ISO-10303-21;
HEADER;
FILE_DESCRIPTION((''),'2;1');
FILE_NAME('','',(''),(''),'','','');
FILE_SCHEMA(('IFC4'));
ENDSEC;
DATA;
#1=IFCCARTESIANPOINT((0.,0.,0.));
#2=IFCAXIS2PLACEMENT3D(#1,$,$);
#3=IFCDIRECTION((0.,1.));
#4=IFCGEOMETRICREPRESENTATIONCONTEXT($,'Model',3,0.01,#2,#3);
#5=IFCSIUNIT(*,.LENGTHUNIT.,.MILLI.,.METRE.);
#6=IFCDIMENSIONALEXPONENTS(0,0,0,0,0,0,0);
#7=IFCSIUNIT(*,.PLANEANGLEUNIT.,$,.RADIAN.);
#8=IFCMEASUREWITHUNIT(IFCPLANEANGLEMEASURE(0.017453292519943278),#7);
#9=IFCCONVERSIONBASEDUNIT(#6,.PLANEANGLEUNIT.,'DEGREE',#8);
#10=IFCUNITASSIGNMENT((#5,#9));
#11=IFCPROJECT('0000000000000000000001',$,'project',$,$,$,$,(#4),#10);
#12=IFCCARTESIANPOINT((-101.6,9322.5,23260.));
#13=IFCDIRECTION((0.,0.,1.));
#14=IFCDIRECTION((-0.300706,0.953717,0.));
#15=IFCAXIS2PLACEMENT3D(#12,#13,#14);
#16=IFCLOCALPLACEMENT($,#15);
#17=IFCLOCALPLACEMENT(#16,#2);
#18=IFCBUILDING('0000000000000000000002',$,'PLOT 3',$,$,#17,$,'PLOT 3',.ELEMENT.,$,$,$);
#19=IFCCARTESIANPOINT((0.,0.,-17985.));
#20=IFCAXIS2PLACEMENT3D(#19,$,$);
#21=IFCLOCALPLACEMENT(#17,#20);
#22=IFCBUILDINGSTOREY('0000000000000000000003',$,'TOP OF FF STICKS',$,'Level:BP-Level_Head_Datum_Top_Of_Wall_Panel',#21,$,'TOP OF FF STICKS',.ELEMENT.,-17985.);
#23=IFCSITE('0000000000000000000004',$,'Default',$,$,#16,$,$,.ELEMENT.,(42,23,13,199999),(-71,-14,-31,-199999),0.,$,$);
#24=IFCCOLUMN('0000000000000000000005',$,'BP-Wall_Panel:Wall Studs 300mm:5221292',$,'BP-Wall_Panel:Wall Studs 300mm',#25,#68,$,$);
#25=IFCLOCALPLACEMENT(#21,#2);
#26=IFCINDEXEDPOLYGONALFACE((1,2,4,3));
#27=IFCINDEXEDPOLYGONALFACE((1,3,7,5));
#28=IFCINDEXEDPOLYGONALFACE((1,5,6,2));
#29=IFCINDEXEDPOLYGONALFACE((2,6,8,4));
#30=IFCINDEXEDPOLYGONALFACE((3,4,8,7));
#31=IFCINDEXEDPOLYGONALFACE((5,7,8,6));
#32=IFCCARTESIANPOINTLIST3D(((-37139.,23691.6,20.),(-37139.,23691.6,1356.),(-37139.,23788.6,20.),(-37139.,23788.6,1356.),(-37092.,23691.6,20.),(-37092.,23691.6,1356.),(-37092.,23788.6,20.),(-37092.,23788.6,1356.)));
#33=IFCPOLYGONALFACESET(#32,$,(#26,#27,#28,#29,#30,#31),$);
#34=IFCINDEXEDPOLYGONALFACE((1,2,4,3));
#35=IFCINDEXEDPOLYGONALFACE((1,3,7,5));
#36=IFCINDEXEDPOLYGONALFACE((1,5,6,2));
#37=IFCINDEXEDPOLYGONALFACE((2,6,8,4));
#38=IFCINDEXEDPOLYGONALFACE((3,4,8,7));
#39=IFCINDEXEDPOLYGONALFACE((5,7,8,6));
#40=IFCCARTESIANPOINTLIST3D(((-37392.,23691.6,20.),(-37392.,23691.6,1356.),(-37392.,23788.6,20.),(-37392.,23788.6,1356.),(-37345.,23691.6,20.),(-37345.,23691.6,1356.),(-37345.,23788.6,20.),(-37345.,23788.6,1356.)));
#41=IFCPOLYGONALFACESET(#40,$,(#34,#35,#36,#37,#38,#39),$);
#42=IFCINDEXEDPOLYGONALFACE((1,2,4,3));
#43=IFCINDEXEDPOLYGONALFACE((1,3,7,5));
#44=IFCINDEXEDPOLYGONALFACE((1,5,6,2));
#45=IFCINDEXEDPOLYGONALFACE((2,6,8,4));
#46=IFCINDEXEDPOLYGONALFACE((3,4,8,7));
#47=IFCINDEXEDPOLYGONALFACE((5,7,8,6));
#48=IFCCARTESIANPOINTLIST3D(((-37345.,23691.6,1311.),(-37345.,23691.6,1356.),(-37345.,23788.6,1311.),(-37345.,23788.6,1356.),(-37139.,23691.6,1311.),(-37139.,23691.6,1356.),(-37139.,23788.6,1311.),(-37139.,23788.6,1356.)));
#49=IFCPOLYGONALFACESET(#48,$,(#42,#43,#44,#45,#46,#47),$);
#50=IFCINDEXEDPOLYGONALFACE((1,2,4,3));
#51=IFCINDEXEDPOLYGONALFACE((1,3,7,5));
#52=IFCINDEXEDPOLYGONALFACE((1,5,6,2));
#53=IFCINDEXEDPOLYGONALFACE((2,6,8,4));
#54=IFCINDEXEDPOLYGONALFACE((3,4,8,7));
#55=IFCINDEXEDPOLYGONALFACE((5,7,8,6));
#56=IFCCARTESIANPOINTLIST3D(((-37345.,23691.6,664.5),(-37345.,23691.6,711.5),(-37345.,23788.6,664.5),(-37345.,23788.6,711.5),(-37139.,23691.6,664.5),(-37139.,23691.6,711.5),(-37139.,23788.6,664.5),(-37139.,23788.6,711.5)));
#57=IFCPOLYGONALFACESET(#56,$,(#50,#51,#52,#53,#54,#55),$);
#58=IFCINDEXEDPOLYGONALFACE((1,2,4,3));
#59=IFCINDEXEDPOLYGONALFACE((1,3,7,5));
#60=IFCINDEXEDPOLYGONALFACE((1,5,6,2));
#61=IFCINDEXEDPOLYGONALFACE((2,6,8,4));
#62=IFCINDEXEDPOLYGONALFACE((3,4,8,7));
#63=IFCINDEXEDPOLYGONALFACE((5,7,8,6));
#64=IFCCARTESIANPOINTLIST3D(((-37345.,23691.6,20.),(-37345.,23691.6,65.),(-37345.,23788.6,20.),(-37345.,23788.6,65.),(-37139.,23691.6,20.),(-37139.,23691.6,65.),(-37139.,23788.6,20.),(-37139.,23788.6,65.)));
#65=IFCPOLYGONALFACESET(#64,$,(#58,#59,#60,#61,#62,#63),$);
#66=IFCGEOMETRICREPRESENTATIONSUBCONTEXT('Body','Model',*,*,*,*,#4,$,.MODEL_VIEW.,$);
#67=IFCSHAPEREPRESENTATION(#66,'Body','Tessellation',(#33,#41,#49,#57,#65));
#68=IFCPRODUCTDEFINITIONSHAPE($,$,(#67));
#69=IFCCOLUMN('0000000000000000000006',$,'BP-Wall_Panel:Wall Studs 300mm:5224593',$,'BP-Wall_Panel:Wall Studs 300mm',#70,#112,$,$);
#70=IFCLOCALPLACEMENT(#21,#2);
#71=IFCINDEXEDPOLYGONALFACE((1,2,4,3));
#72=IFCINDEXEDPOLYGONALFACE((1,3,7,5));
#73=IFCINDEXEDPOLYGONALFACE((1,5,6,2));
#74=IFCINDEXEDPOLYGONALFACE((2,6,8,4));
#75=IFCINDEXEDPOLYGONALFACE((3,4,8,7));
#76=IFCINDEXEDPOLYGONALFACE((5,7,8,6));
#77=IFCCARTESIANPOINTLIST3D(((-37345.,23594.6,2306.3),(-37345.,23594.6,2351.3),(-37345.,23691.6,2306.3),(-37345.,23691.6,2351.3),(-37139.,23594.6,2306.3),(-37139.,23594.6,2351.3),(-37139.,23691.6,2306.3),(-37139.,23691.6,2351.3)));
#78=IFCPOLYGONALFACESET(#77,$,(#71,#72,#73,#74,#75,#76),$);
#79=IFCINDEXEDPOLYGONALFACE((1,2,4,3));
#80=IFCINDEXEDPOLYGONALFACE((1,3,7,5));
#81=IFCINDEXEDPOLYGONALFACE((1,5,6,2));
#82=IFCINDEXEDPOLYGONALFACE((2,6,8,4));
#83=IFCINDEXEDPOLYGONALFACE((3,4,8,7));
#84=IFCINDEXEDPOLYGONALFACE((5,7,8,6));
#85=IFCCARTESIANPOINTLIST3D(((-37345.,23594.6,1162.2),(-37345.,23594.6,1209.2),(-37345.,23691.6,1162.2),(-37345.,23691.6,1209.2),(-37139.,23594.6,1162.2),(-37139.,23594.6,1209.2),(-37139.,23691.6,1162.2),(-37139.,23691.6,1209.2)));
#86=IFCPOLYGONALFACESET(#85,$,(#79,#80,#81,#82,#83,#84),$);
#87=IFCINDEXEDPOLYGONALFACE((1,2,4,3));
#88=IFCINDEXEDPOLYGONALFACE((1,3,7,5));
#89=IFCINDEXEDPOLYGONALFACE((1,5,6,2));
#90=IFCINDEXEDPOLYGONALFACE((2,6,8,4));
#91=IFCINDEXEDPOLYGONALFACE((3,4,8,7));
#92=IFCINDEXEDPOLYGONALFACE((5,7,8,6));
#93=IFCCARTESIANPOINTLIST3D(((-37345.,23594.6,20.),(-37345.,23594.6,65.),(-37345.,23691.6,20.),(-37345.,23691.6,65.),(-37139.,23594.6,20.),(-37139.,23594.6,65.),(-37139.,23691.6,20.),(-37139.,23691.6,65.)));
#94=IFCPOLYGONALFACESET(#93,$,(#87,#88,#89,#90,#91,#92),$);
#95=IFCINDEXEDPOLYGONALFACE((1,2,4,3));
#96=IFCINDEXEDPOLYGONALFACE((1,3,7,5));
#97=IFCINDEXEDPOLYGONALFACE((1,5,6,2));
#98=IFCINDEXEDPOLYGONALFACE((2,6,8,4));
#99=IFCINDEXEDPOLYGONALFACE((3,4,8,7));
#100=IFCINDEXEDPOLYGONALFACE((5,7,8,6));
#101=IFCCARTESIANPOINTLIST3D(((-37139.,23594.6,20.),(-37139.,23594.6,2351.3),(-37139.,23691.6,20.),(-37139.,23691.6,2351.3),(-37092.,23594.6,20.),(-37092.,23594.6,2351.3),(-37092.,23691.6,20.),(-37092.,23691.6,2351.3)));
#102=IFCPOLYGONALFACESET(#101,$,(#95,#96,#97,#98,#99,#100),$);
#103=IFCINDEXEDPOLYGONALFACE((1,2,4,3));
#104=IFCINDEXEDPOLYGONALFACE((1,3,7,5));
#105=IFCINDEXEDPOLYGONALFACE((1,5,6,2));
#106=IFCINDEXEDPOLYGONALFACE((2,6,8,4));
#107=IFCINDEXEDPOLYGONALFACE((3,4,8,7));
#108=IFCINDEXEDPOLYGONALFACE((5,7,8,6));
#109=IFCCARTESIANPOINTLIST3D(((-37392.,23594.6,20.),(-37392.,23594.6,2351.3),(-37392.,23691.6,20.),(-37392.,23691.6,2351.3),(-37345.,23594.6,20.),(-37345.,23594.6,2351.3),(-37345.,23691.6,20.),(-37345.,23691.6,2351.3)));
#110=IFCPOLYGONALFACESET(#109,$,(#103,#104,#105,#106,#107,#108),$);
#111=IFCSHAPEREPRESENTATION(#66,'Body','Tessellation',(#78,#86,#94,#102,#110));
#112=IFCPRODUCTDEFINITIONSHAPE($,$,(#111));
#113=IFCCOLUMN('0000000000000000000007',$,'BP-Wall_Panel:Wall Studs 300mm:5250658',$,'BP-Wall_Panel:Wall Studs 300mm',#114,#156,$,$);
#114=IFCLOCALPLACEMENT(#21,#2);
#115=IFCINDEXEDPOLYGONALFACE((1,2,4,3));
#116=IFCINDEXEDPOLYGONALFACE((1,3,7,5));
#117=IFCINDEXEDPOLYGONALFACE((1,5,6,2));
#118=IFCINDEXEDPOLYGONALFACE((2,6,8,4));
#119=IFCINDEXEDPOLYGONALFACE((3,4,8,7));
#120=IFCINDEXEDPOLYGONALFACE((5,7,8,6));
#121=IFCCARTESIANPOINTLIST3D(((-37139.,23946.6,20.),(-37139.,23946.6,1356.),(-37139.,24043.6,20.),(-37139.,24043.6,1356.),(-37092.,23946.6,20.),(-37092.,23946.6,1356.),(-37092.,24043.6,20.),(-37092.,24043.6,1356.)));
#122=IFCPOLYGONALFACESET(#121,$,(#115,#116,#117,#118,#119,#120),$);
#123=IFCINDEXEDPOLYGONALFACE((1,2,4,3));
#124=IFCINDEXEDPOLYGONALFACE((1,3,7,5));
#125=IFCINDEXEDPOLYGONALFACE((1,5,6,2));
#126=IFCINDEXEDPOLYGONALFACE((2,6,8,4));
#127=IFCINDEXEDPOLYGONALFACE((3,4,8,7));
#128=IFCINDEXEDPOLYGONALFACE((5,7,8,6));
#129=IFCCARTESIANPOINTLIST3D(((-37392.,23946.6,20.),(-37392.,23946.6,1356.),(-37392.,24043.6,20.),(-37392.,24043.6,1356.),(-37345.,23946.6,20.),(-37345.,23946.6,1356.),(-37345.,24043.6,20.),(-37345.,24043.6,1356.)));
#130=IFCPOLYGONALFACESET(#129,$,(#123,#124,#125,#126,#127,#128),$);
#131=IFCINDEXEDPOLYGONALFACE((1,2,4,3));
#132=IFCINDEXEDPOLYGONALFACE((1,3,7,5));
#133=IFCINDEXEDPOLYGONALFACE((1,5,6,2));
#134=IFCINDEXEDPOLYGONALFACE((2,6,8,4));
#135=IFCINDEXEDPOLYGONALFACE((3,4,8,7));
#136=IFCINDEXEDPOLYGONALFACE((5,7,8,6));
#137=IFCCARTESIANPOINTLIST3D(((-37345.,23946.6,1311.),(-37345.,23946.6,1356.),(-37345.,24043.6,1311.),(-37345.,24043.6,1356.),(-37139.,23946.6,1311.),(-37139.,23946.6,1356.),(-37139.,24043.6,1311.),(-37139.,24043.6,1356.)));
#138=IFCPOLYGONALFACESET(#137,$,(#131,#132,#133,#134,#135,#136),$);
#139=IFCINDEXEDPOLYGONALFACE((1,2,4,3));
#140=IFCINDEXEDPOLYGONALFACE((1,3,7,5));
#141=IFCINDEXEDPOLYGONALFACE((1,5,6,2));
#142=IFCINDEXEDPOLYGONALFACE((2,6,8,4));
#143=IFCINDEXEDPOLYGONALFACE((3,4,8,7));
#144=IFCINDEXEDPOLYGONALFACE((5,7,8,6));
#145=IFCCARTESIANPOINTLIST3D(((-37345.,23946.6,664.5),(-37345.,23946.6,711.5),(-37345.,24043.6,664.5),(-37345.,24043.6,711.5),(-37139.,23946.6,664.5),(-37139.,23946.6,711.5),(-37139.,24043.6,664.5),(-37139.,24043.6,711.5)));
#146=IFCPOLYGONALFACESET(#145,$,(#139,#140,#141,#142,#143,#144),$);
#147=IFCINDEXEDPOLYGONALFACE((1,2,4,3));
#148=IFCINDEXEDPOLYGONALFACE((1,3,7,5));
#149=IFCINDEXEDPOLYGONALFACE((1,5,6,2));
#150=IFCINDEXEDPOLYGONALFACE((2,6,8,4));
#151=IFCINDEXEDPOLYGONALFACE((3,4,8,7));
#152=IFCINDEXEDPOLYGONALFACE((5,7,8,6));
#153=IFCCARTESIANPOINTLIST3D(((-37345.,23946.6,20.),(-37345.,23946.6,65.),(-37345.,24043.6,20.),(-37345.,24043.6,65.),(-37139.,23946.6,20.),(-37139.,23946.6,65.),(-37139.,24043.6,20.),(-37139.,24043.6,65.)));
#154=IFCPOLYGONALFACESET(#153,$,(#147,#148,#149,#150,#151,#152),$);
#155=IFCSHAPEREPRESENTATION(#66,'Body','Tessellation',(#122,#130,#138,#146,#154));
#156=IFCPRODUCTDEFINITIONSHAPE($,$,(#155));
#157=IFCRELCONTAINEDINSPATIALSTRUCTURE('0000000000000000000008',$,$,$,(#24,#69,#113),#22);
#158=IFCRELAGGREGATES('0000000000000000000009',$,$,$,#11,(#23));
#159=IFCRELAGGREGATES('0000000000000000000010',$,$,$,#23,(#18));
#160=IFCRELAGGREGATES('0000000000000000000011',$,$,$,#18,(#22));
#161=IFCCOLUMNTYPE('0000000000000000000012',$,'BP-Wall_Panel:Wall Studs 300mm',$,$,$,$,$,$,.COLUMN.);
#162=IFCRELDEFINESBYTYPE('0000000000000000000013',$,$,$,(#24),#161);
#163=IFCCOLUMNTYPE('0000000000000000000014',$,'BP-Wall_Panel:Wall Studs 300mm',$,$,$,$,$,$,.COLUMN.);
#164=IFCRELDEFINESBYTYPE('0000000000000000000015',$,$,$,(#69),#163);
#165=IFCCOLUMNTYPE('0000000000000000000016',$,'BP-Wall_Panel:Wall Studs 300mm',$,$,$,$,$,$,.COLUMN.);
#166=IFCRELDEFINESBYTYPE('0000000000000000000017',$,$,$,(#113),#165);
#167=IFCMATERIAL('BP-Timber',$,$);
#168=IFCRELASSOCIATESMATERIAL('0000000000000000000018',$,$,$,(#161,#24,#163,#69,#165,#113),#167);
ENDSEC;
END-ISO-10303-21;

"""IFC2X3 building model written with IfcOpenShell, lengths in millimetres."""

from ifc_helpers import new_model, entity, si_unit, converted_unit, direction, frame, frame_2d, origin, place, context, subcontext, project, spatial, rectangle, extrude, source, transform, mapped, material, type_object, type_shapes, element, save


model = new_model("IFC2X3")

# Units and contexts
model_context = context("Model", 3, precision=0.01, world=origin(), true_north=direction((0.0, 1.0)))
body_context = subcontext(model_context, "Body", "Model", "MODEL_VIEW")
ifc_project = project(units=[si_unit("LENGTHUNIT", "METRE", prefix="MILLI"), converted_unit("PLANEANGLEUNIT", "DEGREE", entity("IfcPlaneAngleMeasure", 0.017453292519943278), si_unit("PLANEANGLEUNIT", "RADIAN"), dimensions=[0, 0, 0, 0, 0, 0, 0])], contexts=[model_context])

# Site, building, storey
site_placement = place(None, frame((-101.6, 9322.5, 23260.0), z_axis=(0.0, 0.0, 1.0), x_axis=(-0.300706, 0.953717, 0.0)))
site = spatial("IfcSite", under=ifc_project, at=site_placement, Name="Default", CompositionType="ELEMENT", RefLatitude=(42, 23, 13, 199999), RefLongitude=(-71, -14, -31, -199999), RefElevation=0.0)
building_placement = place(site_placement, origin())
building = spatial("IfcBuilding", under=site, at=building_placement, Name="PLOT 3", LongName="PLOT 3", CompositionType="ELEMENT")
storey_placement = place(building_placement, frame((0.0, 0.0, -17985.0)))
storey = spatial("IfcBuildingStorey", under=building, at=storey_placement, Name="TOP OF FF STICKS", ObjectType="Level:BP-Level_Head_Datum_Top_Of_Wall_Panel", LongName="TOP OF FF STICKS", CompositionType="ELEMENT", Elevation=-17985.0)

# Columns
ifc_material_1 = material(Name="BP-Timber")
column_type_1 = type_object("IfcColumnType", Name="BP-Wall_Panel:Wall Studs 300mm", PredefinedType="COLUMN", material=ifc_material_1)
shared_shape_1 = source(origin(), body_context, "Body", "SweptSolid", [
    extrude(rectangle(XDim=47.0, YDim=97.0, at=frame_2d((0.0, 0.0), x_axis=(1.0, 0.0))), frame((-37115.5, 23740.1, -17965.0), z_axis=(0.0, 0.0, 1.0), x_axis=(-1.0, 0.0, 0.0)), (0.0, 0.0, 1.0), 1336.0),
    extrude(rectangle(XDim=47.0, YDim=97.0, at=frame_2d((0.0, 0.0), x_axis=(1.0, 0.0))), frame((-37368.5, 23740.1, -17965.0), z_axis=(0.0, 0.0, 1.0), x_axis=(-1.0, 0.0, 0.0)), (0.0, 0.0, 1.0), 1336.0),
    extrude(rectangle(XDim=97.0, YDim=206.0, at=frame_2d((0.0, 0.0), x_axis=(1.0, 0.0))), frame((-37242.0, 23740.1, -16674.0), z_axis=(0.0, 0.0, 1.0), x_axis=(0.0, 1.0, 0.0)), (0.0, 0.0, 1.0), 45.0),
    extrude(rectangle(XDim=97.0, YDim=206.0, at=frame_2d((0.0, 0.0), x_axis=(1.0, 0.0))), frame((-37242.0, 23740.1, -17320.5), z_axis=(0.0, 0.0, 1.0), x_axis=(0.0, 1.0, 0.0)), (0.0, 0.0, 1.0), 47.0),
    extrude(rectangle(XDim=97.0, YDim=206.0, at=frame_2d((0.0, 0.0), x_axis=(1.0, 0.0))), frame((-37242.0, 23740.1, -17965.0), z_axis=(0.0, 0.0, 1.0), x_axis=(0.0, 1.0, 0.0)), (0.0, 0.0, 1.0), 45.0),
])
type_shapes(column_type_1, [shared_shape_1])
column_1_placement = place(storey_placement, frame((0.0, 0.0, 17985.0)))
element("IfcColumn", 1, at=column_1_placement, inside=storey, type_object=column_type_1, material=ifc_material_1, Name="BP-Wall_Panel:Wall Studs 300mm:5221292", ObjectType="BP-Wall_Panel:Wall Studs 300mm", context=body_context, shape_type="MappedRepresentation", body=[
    mapped(shared_shape_1, transform((0.0, 0.0, 0.0), scale=1.0)),
])
column_type_2 = type_object("IfcColumnType", Name="BP-Wall_Panel:Wall Studs 300mm", PredefinedType="COLUMN", material=ifc_material_1)
shared_shape_2 = source(origin(), body_context, "Body", "SweptSolid", [
    extrude(rectangle(XDim=97.0, YDim=206.0, at=frame_2d((0.0, 0.0), x_axis=(1.0, 0.0))), frame((-37242.0, 23643.1, -15678.7), z_axis=(0.0, 0.0, 1.0), x_axis=(0.0, 1.0, 0.0)), (0.0, 0.0, 1.0), 45.0),
    extrude(rectangle(XDim=97.0, YDim=206.0, at=frame_2d((0.0, 0.0), x_axis=(1.0, 0.0))), frame((-37242.0, 23643.1, -16822.8), z_axis=(0.0, 0.0, 1.0), x_axis=(0.0, 1.0, 0.0)), (0.0, 0.0, 1.0), 47.0),
    extrude(rectangle(XDim=97.0, YDim=206.0, at=frame_2d((0.0, 0.0), x_axis=(1.0, 0.0))), frame((-37242.0, 23643.1, -17965.0), z_axis=(0.0, 0.0, 1.0), x_axis=(0.0, 1.0, 0.0)), (0.0, 0.0, 1.0), 45.0),
    extrude(rectangle(XDim=47.0, YDim=97.0, at=frame_2d((0.0, 0.0), x_axis=(1.0, 0.0))), frame((-37115.5, 23643.1, -17965.0), z_axis=(0.0, 0.0, 1.0), x_axis=(-1.0, 0.0, 0.0)), (0.0, 0.0, 1.0), 2331.3),
    extrude(rectangle(XDim=47.0, YDim=97.0, at=frame_2d((0.0, 0.0), x_axis=(1.0, 0.0))), frame((-37368.5, 23643.1, -17965.0), z_axis=(0.0, 0.0, 1.0), x_axis=(-1.0, 0.0, 0.0)), (0.0, 0.0, 1.0), 2331.3),
])
type_shapes(column_type_2, [shared_shape_2])
column_2_placement = place(storey_placement, frame((0.0, 0.0, 17985.0)))
element("IfcColumn", 2, at=column_2_placement, inside=storey, type_object=column_type_2, material=ifc_material_1, Name="BP-Wall_Panel:Wall Studs 300mm:5224593", ObjectType="BP-Wall_Panel:Wall Studs 300mm", context=body_context, shape_type="MappedRepresentation", body=[
    mapped(shared_shape_2, transform((0.0, 0.0, 0.0), scale=1.0)),
])
column_type_3 = type_object("IfcColumnType", Name="BP-Wall_Panel:Wall Studs 300mm", PredefinedType="COLUMN", material=ifc_material_1)
shared_shape_3 = source(origin(), body_context, "Body", "SweptSolid", [
    extrude(rectangle(XDim=47.0, YDim=97.0, at=frame_2d((0.0, 0.0), x_axis=(1.0, 0.0))), frame((-37115.5, 23995.1, -17965.0), z_axis=(0.0, 0.0, 1.0), x_axis=(-1.0, 0.0, 0.0)), (0.0, 0.0, 1.0), 1336.0),
    extrude(rectangle(XDim=47.0, YDim=97.0, at=frame_2d((0.0, 0.0), x_axis=(1.0, 0.0))), frame((-37368.5, 23995.1, -17965.0), z_axis=(0.0, 0.0, 1.0), x_axis=(-1.0, 0.0, 0.0)), (0.0, 0.0, 1.0), 1336.0),
    extrude(rectangle(XDim=97.0, YDim=206.0, at=frame_2d((0.0, 0.0), x_axis=(1.0, 0.0))), frame((-37242.0, 23995.1, -16674.0), z_axis=(0.0, 0.0, 1.0), x_axis=(0.0, 1.0, 0.0)), (0.0, 0.0, 1.0), 45.0),
    extrude(rectangle(XDim=97.0, YDim=206.0, at=frame_2d((0.0, 0.0), x_axis=(1.0, 0.0))), frame((-37242.0, 23995.1, -17320.5), z_axis=(0.0, 0.0, 1.0), x_axis=(0.0, 1.0, 0.0)), (0.0, 0.0, 1.0), 47.0),
    extrude(rectangle(XDim=97.0, YDim=206.0, at=frame_2d((0.0, 0.0), x_axis=(1.0, 0.0))), frame((-37242.0, 23995.1, -17965.0), z_axis=(0.0, 0.0, 1.0), x_axis=(0.0, 1.0, 0.0)), (0.0, 0.0, 1.0), 45.0),
])
type_shapes(column_type_3, [shared_shape_3])
column_3_placement = place(storey_placement, frame((0.0, 0.0, 17985.0)))
element("IfcColumn", 3, at=column_3_placement, inside=storey, type_object=column_type_3, material=ifc_material_1, Name="BP-Wall_Panel:Wall Studs 300mm:5250658", ObjectType="BP-Wall_Panel:Wall Studs 300mm", context=body_context, shape_type="MappedRepresentation", body=[
    mapped(shared_shape_3, transform((0.0, 0.0, 0.0), scale=1.0)),
])

save(model, "model.ifc")
